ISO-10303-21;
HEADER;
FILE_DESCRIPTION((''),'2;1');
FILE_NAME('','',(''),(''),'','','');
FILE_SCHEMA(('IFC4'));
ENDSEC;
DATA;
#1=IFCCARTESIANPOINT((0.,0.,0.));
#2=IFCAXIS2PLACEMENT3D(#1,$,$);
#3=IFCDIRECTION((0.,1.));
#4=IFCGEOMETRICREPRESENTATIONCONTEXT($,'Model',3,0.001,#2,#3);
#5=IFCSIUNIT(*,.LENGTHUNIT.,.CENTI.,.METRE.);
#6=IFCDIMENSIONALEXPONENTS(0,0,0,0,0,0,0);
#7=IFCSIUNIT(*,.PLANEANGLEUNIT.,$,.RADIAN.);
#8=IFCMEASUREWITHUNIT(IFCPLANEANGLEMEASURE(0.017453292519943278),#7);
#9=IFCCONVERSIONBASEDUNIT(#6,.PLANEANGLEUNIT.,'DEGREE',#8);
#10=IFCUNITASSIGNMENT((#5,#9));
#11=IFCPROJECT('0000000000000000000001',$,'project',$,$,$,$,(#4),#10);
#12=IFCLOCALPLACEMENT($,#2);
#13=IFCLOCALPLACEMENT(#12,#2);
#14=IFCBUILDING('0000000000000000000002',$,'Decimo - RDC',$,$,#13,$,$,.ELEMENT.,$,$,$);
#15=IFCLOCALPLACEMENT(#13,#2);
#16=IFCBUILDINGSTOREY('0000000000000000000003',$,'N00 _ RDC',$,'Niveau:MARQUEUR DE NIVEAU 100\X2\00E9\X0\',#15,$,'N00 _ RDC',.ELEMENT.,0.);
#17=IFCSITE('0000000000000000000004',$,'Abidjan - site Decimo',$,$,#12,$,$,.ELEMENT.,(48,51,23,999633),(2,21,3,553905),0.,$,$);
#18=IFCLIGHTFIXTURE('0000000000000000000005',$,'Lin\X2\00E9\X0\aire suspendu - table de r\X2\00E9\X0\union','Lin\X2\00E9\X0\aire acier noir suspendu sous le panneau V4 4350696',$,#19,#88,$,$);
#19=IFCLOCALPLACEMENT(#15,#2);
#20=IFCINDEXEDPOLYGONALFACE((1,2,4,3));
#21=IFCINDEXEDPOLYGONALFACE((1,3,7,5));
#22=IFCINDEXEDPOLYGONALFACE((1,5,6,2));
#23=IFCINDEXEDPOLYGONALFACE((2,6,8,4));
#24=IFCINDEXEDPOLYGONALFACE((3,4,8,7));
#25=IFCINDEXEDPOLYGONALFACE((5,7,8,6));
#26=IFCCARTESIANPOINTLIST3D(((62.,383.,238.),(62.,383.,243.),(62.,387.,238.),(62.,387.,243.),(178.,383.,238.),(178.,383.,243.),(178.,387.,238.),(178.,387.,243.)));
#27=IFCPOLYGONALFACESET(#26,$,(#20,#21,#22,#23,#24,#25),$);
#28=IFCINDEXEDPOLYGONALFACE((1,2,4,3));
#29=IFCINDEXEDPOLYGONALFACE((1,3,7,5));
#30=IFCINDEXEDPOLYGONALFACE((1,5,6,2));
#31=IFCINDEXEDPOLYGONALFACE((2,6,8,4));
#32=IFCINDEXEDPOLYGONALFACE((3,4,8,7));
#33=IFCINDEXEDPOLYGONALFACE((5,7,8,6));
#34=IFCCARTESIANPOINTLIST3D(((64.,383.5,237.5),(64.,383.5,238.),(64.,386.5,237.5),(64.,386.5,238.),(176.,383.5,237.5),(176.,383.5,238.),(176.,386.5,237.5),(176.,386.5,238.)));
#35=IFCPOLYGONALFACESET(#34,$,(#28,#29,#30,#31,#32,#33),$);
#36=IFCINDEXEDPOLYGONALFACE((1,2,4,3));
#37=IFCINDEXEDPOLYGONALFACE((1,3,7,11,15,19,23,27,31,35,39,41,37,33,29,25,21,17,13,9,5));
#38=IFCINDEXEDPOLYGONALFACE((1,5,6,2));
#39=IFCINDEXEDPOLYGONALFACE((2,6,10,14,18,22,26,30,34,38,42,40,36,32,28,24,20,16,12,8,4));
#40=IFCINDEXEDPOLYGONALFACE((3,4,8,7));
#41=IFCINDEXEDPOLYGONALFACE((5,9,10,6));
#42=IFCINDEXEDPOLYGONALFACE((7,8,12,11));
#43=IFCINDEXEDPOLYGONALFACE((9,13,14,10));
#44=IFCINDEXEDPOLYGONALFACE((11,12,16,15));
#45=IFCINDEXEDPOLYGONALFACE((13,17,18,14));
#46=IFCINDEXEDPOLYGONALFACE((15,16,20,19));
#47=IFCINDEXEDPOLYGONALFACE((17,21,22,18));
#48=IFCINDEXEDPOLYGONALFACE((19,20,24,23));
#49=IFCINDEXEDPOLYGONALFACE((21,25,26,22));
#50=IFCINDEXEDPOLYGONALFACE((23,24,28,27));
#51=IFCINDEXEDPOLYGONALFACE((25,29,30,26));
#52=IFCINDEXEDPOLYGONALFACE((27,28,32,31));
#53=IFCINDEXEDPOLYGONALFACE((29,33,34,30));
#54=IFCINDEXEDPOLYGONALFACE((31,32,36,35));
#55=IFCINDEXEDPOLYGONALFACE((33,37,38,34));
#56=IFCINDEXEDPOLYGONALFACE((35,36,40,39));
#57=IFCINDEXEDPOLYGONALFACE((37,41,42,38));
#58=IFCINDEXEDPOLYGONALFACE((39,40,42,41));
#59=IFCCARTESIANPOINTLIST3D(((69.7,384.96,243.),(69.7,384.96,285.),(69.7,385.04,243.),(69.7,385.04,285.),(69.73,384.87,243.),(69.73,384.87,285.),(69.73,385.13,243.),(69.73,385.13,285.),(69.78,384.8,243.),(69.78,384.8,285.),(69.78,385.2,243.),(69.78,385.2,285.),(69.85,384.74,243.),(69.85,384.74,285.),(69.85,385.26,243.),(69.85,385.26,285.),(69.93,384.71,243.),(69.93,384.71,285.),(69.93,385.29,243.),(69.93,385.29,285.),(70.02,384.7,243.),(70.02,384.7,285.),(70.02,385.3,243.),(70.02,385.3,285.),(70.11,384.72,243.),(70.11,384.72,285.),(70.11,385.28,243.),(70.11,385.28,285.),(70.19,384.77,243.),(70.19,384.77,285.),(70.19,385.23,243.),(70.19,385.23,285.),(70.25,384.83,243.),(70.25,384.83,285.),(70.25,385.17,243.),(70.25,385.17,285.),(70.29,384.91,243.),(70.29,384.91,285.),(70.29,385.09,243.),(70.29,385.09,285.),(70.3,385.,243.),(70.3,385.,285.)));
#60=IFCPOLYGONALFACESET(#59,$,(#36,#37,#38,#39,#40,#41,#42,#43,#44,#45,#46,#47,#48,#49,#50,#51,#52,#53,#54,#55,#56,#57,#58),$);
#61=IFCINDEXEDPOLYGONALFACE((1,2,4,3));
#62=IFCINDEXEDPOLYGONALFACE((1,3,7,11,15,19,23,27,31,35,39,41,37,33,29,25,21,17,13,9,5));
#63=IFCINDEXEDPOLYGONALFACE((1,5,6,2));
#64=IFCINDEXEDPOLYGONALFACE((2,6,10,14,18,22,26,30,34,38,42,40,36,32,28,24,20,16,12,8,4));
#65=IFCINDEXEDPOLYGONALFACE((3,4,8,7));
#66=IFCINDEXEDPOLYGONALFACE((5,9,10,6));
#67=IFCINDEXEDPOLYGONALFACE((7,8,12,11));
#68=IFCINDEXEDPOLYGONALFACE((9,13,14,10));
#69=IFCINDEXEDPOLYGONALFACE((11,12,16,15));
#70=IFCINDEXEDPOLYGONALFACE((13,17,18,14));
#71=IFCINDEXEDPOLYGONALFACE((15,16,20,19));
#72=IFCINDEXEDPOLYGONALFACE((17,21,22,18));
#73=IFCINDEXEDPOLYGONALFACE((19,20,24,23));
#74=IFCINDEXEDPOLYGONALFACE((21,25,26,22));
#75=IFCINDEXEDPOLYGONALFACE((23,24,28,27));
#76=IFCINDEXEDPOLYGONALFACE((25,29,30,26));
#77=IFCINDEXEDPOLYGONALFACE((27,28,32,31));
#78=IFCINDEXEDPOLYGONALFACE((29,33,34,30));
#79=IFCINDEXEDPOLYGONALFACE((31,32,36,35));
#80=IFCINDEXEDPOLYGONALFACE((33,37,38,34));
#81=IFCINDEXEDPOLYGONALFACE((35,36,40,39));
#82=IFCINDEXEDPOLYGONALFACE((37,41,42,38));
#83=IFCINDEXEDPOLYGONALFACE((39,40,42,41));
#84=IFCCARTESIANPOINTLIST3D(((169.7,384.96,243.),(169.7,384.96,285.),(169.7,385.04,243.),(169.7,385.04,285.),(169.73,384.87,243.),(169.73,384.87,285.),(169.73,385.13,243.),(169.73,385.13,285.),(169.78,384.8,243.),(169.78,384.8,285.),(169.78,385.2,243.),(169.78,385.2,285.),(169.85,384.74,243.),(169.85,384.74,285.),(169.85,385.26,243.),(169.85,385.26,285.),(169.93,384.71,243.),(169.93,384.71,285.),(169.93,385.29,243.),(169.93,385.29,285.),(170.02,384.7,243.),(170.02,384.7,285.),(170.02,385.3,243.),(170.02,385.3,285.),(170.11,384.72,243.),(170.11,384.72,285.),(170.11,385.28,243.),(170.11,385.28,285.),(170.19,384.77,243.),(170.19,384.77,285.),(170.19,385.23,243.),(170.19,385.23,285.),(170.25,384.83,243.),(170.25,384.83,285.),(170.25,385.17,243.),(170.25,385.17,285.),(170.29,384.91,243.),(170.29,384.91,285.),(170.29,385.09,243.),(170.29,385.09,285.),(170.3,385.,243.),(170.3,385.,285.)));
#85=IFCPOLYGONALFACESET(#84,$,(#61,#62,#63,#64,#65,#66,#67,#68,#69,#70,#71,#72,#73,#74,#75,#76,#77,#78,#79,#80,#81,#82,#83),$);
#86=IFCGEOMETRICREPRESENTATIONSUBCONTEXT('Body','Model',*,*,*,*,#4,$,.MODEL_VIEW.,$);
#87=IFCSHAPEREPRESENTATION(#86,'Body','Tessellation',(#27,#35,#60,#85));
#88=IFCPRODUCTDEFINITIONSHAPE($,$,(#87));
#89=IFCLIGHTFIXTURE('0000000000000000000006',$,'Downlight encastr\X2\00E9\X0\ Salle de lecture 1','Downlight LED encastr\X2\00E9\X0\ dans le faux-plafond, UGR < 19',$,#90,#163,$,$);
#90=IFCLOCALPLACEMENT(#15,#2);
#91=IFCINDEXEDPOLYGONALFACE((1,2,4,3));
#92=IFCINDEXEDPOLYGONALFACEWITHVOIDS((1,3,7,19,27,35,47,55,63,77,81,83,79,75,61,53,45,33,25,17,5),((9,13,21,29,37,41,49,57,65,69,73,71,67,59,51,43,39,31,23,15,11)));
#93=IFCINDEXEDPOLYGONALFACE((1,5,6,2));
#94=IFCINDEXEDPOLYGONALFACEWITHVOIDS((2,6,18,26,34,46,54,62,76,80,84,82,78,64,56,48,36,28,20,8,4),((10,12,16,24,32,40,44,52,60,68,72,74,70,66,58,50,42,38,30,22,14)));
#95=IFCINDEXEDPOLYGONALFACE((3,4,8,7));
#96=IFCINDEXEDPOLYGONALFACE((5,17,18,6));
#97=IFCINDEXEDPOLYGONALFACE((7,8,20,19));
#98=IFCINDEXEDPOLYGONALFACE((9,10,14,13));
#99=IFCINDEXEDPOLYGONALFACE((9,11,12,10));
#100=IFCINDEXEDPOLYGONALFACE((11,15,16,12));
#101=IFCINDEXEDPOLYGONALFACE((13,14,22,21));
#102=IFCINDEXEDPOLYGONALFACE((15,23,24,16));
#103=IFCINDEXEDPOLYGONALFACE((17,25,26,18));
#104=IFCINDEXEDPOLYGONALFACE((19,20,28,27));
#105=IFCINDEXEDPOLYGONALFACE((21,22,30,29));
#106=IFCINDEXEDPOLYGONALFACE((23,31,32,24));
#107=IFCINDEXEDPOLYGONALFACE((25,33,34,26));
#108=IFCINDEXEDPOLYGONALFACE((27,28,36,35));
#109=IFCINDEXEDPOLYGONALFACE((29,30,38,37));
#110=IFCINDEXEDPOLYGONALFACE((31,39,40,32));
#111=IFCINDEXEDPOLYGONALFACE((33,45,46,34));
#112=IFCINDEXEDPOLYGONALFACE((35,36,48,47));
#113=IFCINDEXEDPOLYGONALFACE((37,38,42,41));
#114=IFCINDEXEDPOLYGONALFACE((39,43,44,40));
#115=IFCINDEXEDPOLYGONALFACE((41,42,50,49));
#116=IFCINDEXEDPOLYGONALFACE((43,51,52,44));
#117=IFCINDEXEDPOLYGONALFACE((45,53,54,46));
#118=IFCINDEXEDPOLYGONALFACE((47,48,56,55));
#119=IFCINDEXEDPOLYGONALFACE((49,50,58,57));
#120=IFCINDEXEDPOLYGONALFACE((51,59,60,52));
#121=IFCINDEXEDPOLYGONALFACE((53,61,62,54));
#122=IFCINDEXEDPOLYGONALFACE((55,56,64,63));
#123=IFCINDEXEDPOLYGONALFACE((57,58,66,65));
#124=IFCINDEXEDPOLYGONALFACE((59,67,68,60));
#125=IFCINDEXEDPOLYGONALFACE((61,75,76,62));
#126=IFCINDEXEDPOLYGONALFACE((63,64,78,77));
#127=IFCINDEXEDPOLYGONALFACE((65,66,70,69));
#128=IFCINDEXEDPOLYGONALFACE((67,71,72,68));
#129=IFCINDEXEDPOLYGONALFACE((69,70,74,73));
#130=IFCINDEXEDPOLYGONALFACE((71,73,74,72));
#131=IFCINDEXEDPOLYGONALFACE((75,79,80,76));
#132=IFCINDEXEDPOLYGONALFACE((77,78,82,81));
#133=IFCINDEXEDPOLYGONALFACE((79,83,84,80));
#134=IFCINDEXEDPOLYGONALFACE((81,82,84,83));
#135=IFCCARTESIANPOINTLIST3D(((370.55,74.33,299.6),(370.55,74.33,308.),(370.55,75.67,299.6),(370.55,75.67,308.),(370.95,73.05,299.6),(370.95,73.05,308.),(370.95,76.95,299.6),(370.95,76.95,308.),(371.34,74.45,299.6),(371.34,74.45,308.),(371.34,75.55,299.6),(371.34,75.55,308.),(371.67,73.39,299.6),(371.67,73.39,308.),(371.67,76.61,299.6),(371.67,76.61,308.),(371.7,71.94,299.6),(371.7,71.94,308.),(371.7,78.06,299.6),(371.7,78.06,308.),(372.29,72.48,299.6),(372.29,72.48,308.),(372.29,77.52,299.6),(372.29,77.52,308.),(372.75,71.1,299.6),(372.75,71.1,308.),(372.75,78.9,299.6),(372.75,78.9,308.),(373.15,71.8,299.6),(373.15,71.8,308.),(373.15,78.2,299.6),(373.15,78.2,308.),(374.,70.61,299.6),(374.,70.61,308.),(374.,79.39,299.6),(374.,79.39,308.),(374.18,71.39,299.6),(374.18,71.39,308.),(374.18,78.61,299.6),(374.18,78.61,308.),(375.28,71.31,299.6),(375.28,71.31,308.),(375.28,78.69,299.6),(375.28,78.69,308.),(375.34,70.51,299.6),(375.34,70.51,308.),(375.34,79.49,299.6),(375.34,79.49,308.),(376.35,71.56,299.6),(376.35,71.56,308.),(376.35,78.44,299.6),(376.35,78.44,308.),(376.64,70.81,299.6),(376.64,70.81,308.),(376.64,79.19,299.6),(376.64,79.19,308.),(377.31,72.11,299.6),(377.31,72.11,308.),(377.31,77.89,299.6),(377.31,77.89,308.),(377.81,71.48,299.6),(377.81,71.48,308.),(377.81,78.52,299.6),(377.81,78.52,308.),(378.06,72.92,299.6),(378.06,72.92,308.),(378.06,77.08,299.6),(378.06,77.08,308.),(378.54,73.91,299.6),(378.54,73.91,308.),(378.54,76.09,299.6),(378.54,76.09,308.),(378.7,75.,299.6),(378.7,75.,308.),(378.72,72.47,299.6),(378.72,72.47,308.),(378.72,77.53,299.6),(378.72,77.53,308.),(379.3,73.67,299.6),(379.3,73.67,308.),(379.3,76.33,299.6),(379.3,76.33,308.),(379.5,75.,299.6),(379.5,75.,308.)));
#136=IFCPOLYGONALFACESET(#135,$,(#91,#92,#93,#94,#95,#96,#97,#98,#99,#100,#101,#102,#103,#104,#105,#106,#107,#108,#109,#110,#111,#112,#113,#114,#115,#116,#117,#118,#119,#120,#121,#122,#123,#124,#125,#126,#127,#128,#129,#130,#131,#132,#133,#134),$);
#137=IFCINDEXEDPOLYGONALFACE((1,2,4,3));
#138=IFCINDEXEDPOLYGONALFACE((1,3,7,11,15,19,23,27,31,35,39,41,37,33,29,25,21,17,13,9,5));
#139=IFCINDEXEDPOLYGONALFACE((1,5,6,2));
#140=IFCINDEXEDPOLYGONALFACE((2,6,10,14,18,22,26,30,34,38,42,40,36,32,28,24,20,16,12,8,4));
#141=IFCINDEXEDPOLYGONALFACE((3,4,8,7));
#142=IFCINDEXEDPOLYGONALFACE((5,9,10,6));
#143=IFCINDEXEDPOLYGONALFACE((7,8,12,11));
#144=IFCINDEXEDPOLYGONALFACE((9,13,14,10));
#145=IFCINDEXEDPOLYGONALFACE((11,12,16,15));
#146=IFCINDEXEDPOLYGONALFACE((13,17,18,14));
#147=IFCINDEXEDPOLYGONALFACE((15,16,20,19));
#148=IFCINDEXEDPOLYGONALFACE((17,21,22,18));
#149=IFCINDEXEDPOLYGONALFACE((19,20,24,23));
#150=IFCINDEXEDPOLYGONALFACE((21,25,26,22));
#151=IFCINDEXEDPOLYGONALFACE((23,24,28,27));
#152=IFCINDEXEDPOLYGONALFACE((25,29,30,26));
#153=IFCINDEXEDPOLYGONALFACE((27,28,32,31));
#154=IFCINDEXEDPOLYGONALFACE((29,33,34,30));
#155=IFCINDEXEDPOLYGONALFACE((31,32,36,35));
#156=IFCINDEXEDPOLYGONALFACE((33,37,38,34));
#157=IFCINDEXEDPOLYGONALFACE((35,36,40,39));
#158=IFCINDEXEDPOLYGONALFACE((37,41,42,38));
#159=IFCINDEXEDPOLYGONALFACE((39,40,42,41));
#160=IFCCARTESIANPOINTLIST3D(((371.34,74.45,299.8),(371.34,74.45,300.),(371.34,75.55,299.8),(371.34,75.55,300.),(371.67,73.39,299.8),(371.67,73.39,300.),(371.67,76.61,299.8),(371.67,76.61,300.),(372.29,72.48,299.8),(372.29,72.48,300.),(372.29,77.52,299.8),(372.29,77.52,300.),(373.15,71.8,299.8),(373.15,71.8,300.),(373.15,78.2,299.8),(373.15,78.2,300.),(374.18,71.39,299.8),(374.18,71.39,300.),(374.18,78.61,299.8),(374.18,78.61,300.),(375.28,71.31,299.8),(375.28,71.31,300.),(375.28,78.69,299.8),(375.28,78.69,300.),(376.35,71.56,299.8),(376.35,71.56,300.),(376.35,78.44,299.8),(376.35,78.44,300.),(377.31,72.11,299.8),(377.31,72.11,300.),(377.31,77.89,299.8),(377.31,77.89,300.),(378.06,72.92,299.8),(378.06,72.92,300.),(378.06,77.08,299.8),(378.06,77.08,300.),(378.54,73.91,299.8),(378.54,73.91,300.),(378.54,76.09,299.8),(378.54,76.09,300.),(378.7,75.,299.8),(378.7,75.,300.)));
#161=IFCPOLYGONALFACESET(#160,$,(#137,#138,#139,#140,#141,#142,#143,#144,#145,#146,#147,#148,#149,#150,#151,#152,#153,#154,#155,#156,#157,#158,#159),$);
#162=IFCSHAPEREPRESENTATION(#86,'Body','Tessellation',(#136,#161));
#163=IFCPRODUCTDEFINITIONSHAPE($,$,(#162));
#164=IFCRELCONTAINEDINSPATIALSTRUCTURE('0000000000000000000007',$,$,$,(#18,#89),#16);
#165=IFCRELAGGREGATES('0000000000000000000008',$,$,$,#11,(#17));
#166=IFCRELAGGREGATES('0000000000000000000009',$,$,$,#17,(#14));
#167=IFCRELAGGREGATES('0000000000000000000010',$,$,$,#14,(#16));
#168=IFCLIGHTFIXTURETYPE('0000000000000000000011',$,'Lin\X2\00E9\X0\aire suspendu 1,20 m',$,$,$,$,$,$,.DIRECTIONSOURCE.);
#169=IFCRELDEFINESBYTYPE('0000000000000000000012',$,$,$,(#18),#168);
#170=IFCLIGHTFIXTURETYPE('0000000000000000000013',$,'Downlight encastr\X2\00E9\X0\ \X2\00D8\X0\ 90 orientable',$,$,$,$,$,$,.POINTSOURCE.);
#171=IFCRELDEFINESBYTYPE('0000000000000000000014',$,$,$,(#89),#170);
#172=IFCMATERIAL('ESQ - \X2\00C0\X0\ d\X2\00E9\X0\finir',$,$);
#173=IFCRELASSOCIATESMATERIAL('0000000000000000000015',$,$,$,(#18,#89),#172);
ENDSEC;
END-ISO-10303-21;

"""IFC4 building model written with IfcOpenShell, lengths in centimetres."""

from ifc_helpers import new_model, entity, si_unit, converted_unit, direction, frame, frame_2d, origin, origin_with_axes, place, context, subcontext, project, spatial, rectangle, circle, hollow_circle, extrude, material, type_object, element, save


model = new_model("IFC4")

# Units and contexts
model_context = context("Model", 3, precision=0.001, world=origin(), true_north=direction((0.0, 1.0)))
body_context = subcontext(model_context, "Body", "Model", "MODEL_VIEW")
ifc_project = project(units=[si_unit("LENGTHUNIT", "METRE", prefix="CENTI"), converted_unit("PLANEANGLEUNIT", "DEGREE", entity("IfcPlaneAngleMeasure", 0.017453292519943278), si_unit("PLANEANGLEUNIT", "RADIAN"), dimensions=[0, 0, 0, 0, 0, 0, 0])], contexts=[model_context])

# Site, building, storey
site_placement = place(None, origin())
site = spatial("IfcSite", under=ifc_project, at=site_placement, Name="Abidjan - site Decimo", CompositionType="ELEMENT", RefLatitude=(48, 51, 23, 999633), RefLongitude=(2, 21, 3, 553905), RefElevation=0.0)
building_placement = place(site_placement, origin())
building = spatial("IfcBuilding", under=site, at=building_placement, Name="Decimo - RDC", CompositionType="ELEMENT")
storey_placement = place(building_placement, origin())
storey = spatial("IfcBuildingStorey", under=building, at=storey_placement, Name="N00 _ RDC", ObjectType="Niveau:MARQUEUR DE NIVEAU 100é", LongName="N00 _ RDC", CompositionType="ELEMENT", Elevation=0.0)

# Light fixtures
ifc_material_1 = material(Name="ESQ - À définir")
light_fixture_type_1 = type_object("IfcLightFixtureType", Name="Linéaire suspendu 1,20 m", PredefinedType="DIRECTIONSOURCE")
light_fixture_1_placement = place(storey_placement, origin_with_axes())
element("IfcLightFixture", 1, at=light_fixture_1_placement, inside=storey, type_object=light_fixture_type_1, material=ifc_material_1, Name="Linéaire suspendu - table de réunion", Description="Linéaire acier noir suspendu sous le panneau V4 4350696", context=body_context, shape_type="SweptSolid", body=[
    extrude(rectangle(XDim=116.0, YDim=4.0, at=frame_2d((120.0, 385.0))), frame((0.0, 0.0, 238.0)), (0.0, 0.0, 1.0), 5.0),
    extrude(rectangle(XDim=112.0, YDim=3.0, at=frame_2d((120.0, 385.0))), frame((0.0, 0.0, 237.5)), (0.0, 0.0, 1.0), 0.5),
    extrude(circle(Radius=0.3, at=frame_2d((70.0, 385.0))), frame((0.0, 0.0, 243.0)), (0.0, 0.0, 1.0), 42.0),
    extrude(circle(Radius=0.3, at=frame_2d((170.0, 385.0))), frame((0.0, 0.0, 243.0)), (0.0, 0.0, 1.0), 42.0),
])
light_fixture_type_2 = type_object("IfcLightFixtureType", Name="Downlight encastré Ø 90 orientable", PredefinedType="POINTSOURCE")
light_fixture_2_placement = place(storey_placement, origin_with_axes())
element("IfcLightFixture", 2, at=light_fixture_2_placement, inside=storey, type_object=light_fixture_type_2, material=ifc_material_1, Name="Downlight encastré Salle de lecture 1", Description="Downlight LED encastré dans le faux-plafond, UGR < 19", context=body_context, shape_type="SweptSolid", body=[
    extrude(hollow_circle(Radius=4.5, WallThickness=0.8, at=frame_2d((375.0, 75.0))), frame((0.0, 0.0, 299.6)), (0.0, 0.0, 1.0), 8.4),
    extrude(circle(Radius=3.7, at=frame_2d((375.0, 75.0))), frame((0.0, 0.0, 299.8)), (0.0, 0.0, 1.0), 0.2),
])

save(model, "model.ifc")
